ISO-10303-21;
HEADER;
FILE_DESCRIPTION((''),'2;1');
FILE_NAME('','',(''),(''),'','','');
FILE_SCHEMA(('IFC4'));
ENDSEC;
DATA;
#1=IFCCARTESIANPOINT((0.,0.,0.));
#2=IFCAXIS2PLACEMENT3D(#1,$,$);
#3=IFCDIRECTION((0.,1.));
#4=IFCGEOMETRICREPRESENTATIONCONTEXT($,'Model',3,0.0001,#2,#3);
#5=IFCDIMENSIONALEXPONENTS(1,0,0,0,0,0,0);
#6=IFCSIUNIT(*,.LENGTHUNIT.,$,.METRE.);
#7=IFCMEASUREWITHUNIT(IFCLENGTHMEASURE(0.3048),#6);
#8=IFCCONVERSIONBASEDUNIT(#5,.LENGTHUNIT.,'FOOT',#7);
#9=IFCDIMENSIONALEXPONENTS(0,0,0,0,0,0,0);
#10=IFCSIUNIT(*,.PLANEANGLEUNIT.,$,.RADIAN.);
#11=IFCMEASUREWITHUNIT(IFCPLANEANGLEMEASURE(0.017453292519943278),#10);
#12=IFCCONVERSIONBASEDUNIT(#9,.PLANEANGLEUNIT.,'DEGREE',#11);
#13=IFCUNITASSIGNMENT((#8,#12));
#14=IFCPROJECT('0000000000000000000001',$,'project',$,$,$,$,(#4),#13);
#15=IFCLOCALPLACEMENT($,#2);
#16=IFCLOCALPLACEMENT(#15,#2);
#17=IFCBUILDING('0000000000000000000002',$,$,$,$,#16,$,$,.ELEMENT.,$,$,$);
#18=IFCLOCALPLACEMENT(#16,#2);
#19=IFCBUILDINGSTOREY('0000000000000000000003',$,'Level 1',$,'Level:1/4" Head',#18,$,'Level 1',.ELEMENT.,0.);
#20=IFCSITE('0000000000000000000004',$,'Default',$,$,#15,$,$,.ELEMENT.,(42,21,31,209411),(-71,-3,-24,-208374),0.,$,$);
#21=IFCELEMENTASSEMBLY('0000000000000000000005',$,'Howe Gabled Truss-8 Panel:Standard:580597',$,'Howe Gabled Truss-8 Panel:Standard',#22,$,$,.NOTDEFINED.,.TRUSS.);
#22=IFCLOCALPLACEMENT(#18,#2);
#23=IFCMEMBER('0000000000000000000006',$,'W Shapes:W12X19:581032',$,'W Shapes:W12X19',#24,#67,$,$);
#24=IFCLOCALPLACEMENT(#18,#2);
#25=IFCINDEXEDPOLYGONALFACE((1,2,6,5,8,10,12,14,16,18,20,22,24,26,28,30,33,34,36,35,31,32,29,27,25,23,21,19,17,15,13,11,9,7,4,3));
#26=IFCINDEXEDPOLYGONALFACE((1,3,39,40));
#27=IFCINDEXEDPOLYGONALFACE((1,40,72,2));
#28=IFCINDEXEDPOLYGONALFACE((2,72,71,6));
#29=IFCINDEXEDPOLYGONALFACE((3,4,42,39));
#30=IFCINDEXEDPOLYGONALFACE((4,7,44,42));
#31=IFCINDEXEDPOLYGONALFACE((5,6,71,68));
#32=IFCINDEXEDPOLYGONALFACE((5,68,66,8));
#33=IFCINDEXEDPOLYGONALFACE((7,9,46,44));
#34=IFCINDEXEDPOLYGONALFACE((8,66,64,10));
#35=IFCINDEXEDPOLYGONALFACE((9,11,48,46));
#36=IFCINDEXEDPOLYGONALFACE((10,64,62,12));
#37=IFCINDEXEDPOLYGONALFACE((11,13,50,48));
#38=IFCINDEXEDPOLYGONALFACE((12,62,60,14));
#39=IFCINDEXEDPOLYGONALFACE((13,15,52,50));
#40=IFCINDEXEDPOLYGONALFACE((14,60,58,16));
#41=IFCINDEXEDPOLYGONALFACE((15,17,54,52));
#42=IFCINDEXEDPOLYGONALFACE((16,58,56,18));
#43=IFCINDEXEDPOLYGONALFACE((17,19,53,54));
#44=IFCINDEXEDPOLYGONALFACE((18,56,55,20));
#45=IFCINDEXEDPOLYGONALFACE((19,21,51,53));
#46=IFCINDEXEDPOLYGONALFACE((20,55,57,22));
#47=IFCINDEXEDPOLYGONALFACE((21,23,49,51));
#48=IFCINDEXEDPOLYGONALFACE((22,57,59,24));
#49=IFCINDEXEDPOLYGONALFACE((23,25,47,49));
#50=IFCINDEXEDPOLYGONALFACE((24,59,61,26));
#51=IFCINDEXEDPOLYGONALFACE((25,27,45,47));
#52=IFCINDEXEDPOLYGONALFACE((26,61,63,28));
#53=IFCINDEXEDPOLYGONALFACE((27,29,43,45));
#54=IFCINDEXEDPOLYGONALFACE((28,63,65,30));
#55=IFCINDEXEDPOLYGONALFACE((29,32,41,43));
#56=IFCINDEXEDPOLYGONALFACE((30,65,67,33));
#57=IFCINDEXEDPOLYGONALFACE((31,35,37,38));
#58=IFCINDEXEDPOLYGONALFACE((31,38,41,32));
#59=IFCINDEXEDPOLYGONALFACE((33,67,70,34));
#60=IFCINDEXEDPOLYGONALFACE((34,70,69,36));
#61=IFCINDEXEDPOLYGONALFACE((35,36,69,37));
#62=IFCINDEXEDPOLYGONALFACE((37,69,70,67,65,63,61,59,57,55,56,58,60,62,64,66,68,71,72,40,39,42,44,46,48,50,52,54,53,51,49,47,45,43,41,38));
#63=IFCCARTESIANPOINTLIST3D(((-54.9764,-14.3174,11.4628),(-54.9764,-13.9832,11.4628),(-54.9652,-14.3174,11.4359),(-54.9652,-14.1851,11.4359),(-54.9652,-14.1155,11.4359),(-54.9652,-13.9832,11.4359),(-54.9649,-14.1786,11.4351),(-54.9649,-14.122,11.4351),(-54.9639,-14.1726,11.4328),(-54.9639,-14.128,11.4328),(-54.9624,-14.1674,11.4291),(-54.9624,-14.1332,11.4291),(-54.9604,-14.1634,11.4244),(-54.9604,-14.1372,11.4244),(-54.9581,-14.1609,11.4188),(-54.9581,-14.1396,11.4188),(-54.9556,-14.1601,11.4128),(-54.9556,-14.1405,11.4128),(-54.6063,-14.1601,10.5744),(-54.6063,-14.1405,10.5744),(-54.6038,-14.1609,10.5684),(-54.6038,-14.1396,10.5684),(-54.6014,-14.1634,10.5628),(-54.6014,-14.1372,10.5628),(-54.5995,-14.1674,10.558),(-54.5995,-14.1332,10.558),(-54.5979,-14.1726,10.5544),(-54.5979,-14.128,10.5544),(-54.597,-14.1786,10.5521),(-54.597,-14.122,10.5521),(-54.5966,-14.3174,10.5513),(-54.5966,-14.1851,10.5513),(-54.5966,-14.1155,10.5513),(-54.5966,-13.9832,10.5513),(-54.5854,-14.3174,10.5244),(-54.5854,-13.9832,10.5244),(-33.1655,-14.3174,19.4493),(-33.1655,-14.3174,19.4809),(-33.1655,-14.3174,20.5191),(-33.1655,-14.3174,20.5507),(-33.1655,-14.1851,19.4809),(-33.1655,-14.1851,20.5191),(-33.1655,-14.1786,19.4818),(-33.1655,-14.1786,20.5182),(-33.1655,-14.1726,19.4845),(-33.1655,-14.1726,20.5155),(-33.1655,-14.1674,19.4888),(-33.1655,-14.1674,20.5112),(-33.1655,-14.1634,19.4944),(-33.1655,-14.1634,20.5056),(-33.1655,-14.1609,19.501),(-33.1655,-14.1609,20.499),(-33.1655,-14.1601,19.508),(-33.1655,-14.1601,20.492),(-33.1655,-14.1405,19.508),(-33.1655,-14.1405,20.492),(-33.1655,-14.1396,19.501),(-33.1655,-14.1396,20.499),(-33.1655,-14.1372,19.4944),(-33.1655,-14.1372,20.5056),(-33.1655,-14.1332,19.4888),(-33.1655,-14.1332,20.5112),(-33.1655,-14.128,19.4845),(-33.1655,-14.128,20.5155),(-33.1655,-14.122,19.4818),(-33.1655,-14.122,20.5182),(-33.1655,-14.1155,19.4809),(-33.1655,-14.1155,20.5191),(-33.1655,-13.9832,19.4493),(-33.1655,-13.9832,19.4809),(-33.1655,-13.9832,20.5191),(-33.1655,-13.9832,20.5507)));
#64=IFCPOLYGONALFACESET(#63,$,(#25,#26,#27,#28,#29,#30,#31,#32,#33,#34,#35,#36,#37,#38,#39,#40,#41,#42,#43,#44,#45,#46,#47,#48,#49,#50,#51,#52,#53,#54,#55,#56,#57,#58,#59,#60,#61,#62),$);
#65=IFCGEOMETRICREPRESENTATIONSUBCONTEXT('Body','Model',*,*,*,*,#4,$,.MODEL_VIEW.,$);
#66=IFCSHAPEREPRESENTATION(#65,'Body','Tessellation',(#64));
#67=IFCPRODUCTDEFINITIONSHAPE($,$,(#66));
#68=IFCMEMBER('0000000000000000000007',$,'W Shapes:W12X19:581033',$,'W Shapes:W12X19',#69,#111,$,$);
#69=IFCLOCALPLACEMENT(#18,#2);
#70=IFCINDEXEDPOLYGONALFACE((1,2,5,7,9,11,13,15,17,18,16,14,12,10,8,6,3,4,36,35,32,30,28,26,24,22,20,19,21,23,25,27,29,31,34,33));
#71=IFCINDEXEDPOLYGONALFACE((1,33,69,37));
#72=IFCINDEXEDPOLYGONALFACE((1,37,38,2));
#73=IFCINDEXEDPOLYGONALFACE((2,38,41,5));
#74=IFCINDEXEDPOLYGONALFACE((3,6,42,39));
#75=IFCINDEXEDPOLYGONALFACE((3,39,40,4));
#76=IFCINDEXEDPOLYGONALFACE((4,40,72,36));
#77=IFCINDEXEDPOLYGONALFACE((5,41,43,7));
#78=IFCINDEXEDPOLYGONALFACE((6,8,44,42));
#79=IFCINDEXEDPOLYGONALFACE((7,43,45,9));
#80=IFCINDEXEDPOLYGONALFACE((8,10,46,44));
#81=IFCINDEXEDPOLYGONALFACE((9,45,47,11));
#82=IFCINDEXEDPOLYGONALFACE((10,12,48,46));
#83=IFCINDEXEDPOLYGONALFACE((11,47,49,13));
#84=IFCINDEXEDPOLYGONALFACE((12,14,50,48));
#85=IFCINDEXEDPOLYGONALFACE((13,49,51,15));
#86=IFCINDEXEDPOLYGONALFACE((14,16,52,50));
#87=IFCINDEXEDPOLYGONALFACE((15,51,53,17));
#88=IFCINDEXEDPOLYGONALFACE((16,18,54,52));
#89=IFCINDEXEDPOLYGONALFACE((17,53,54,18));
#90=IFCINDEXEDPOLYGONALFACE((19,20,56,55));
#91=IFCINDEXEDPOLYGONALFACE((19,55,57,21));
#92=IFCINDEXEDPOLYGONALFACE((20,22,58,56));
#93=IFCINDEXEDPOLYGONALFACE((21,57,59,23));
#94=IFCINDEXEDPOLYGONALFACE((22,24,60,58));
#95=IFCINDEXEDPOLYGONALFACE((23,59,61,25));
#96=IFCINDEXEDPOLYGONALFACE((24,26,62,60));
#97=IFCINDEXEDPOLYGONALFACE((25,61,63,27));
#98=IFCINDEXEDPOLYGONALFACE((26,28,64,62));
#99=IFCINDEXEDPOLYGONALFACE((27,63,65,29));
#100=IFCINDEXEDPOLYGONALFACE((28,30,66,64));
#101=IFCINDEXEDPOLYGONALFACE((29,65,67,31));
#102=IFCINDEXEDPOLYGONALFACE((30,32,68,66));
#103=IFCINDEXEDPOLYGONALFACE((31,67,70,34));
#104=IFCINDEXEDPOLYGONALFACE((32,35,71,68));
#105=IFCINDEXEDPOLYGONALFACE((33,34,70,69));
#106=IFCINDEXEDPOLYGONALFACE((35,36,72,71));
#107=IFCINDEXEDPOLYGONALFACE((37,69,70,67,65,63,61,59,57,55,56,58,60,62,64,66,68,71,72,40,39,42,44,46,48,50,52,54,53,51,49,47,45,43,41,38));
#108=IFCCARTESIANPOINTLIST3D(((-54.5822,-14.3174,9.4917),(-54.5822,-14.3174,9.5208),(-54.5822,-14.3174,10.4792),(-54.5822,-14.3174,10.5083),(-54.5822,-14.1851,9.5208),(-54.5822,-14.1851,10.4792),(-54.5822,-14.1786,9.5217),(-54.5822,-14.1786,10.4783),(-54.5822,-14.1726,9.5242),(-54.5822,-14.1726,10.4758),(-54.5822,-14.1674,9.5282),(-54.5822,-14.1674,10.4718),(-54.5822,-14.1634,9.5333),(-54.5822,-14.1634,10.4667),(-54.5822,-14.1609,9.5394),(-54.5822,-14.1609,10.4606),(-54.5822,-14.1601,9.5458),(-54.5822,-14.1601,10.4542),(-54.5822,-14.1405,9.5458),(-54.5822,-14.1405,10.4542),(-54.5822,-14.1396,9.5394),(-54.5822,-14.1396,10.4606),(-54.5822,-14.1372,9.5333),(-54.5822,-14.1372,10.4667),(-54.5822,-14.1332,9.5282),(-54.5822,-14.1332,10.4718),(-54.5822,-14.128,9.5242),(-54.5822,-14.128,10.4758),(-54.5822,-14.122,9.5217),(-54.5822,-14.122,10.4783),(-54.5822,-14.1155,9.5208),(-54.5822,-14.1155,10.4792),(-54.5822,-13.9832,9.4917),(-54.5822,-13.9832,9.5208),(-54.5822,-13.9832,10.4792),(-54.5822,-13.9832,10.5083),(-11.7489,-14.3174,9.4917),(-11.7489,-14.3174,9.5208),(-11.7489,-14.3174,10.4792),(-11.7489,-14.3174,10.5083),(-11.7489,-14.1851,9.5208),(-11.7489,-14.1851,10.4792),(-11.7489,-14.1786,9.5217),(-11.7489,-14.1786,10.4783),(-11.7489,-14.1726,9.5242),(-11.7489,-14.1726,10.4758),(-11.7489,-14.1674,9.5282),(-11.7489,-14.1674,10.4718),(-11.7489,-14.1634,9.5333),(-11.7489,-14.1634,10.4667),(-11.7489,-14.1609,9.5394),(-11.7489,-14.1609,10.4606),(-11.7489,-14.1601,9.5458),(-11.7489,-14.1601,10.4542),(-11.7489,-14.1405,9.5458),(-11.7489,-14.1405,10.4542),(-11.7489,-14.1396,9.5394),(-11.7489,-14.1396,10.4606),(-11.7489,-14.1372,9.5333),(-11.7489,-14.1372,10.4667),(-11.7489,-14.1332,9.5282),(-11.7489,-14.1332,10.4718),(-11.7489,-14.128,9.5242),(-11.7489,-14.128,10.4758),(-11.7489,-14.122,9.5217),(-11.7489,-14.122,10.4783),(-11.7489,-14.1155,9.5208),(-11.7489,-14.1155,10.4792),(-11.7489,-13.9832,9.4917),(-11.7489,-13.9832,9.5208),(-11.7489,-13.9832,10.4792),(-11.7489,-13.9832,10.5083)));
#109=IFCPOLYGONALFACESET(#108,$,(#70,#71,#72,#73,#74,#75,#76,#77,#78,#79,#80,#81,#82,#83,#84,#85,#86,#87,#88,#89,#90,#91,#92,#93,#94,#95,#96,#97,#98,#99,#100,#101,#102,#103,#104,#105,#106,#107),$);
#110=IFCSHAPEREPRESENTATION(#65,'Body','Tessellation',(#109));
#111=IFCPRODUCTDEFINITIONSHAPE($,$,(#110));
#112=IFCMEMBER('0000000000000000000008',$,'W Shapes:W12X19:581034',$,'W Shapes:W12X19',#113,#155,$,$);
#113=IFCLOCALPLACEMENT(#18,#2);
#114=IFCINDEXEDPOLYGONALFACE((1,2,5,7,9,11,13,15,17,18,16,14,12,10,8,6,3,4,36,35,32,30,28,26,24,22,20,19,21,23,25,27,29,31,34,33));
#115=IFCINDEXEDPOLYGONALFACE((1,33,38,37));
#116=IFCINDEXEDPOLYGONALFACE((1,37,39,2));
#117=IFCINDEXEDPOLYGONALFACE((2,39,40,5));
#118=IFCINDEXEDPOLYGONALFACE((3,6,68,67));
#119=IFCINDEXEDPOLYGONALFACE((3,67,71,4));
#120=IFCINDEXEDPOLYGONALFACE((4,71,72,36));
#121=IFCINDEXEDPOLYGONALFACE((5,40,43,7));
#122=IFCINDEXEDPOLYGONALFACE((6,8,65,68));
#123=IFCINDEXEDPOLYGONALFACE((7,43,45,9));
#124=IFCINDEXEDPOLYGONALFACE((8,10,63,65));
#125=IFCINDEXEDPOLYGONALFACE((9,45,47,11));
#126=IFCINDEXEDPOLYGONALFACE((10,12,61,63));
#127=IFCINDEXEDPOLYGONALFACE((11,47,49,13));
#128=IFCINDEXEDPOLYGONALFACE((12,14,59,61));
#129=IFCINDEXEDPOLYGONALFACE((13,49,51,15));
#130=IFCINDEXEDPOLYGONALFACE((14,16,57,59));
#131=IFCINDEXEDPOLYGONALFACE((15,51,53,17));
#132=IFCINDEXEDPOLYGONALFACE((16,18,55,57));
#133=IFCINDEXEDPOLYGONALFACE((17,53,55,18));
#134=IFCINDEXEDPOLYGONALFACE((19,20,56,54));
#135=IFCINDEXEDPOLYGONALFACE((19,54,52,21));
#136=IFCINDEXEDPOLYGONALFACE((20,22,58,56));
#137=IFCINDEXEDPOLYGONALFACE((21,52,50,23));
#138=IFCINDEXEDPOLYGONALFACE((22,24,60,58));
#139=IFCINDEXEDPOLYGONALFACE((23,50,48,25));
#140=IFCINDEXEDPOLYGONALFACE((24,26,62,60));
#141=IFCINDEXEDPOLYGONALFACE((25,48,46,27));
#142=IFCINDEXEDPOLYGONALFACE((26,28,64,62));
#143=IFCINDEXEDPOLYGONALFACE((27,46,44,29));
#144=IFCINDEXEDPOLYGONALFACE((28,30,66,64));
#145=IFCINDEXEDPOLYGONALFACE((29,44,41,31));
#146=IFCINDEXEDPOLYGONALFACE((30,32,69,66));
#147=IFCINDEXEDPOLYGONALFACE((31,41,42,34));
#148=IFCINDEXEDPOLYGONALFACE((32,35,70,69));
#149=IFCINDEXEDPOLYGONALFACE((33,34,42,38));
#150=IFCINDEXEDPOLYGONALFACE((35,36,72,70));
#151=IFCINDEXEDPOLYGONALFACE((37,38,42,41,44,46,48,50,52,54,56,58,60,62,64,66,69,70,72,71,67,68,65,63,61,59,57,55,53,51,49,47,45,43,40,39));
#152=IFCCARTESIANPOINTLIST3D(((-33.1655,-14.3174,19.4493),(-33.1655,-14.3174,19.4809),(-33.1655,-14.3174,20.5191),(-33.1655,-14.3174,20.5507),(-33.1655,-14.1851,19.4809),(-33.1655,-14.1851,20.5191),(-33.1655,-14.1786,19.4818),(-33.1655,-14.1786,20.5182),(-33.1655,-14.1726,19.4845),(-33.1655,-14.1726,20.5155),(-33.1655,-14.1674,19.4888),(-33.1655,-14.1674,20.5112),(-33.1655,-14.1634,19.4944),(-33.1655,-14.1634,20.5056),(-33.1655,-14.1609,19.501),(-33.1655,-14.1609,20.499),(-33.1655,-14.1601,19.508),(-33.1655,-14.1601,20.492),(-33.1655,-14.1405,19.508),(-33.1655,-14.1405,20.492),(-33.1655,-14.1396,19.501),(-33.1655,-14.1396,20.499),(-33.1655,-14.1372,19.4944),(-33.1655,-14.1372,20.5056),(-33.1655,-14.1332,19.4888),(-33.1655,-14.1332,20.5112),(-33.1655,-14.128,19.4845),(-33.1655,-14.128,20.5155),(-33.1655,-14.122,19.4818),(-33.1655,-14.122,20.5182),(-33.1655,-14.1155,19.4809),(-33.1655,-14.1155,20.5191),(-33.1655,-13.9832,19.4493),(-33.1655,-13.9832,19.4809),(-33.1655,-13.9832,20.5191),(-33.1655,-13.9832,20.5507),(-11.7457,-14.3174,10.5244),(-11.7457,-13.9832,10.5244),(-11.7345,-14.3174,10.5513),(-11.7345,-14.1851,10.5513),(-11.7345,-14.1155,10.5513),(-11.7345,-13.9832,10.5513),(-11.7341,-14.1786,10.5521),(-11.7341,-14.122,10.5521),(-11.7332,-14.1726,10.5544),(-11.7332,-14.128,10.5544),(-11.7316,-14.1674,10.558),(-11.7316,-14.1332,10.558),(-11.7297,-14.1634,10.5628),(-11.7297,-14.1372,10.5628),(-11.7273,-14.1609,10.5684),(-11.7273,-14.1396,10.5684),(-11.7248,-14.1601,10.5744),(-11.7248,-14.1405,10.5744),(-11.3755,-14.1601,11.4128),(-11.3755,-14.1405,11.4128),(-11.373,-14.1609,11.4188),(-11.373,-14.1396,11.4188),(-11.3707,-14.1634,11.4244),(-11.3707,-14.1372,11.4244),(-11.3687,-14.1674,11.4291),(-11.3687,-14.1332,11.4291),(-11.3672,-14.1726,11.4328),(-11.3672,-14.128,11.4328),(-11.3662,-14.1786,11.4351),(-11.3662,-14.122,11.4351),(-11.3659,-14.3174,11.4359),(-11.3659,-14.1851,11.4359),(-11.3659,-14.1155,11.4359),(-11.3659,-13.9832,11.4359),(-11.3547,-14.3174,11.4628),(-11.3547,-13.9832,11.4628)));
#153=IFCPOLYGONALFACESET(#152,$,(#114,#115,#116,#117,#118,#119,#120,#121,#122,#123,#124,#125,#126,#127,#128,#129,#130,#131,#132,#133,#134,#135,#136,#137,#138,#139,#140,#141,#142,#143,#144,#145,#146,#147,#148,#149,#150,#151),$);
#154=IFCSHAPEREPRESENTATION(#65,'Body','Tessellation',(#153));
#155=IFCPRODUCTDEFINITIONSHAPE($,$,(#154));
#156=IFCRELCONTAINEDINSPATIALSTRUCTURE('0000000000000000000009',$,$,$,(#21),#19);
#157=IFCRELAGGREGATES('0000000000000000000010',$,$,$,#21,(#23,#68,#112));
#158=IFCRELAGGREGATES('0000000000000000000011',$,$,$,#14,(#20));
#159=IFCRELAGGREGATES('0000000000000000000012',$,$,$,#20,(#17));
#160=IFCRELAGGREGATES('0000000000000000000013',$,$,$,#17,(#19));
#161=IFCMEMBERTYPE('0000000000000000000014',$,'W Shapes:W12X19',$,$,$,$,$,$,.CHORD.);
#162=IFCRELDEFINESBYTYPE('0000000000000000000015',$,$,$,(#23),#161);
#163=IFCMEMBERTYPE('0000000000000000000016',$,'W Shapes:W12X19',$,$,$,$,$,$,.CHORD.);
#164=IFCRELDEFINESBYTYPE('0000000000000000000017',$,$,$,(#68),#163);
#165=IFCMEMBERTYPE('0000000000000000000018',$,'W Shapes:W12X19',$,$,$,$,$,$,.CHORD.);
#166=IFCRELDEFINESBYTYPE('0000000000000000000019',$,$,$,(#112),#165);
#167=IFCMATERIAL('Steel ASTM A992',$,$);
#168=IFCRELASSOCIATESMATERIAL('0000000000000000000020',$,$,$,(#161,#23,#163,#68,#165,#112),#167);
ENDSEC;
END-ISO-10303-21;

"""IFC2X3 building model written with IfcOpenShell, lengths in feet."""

from ifc_helpers import new_model, entity, si_unit, converted_unit, direction, frame, frame_2d, origin, place, context, subcontext, project, spatial, polyline, circle_curve, parameter, trimmed, segment, composite_curve, i_section, outline, extrude, clip, halfspace, source, transform, mapped, material, type_object, type_shapes, element, aggregate, save


model = new_model("IFC2X3")

# Units and contexts
model_context = context("Model", 3, precision=0.0001, world=origin(), true_north=direction((0.0, 1.0)))
body_context = subcontext(model_context, "Body", "Model", "MODEL_VIEW")
ifc_project = project(units=[converted_unit("LENGTHUNIT", "FOOT", entity("IfcLengthMeasure", 0.3048), si_unit("LENGTHUNIT", "METRE"), dimensions=[1, 0, 0, 0, 0, 0, 0]), converted_unit("PLANEANGLEUNIT", "DEGREE", entity("IfcPlaneAngleMeasure", 0.017453292519943278), si_unit("PLANEANGLEUNIT", "RADIAN"), dimensions=[0, 0, 0, 0, 0, 0, 0])], contexts=[model_context])

# Site, building, storey
site_placement = place(None, origin())
site = spatial("IfcSite", under=ifc_project, at=site_placement, Name="Default", CompositionType="ELEMENT", RefLatitude=(42, 21, 31, 209411), RefLongitude=(-71, -3, -24, -208374), RefElevation=0.0)
building_placement = place(site_placement, origin())
building = spatial("IfcBuilding", under=site, at=building_placement, CompositionType="ELEMENT")
storey_placement = place(building_placement, origin())
storey = spatial("IfcBuildingStorey", under=building, at=storey_placement, Name="Level 1", ObjectType="Level:1/4\" Head", LongName="Level 1", CompositionType="ELEMENT", Elevation=0.0)

# Element assembly, members
assembly_placement = place(storey_placement, origin())
assembly = element("IfcElementAssembly", 1, at=assembly_placement, inside=storey, Name="Howe Gabled Truss-8 Panel:Standard:580597", ObjectType="Howe Gabled Truss-8 Panel:Standard", AssemblyPlace="NOTDEFINED", PredefinedType="TRUSS")
ifc_material = material(Name="Steel ASTM A992")
member_type_1 = type_object("IfcMemberType", Name="W Shapes:W12X19", PredefinedType="CHORD", material=ifc_material)
shared_shape_1 = source(origin(), body_context, "Body", "Clipping", [
    clip(extrude(i_section(OverallWidth=0.3342, OverallDepth=1.0167, WebThickness=0.0196, FlangeThickness=0.0292, FilletRadius=0.025, at=frame_2d((0.0, 0.0), x_axis=(1.0, 0.0))), frame((-54.7809, -14.1503, 10.9936), z_axis=(0.923077, 0.0, 0.384615), x_axis=(0.0, -1.0, 0.0)), (0.0, 0.0, 1.0), 23.6285), halfspace(frame((-33.1655, -14.1503, 20.5507), z_axis=(1.0, 0.0, 0.0), x_axis=(0.0, -1.0, 0.0)), False)),
])
type_shapes(member_type_1, [shared_shape_1])
member_1_placement = place(assembly_placement, origin())
member_1 = element("IfcMember", 2, at=member_1_placement, type_object=member_type_1, material=ifc_material, Name="W Shapes:W12X19:581032", ObjectType="W Shapes:W12X19", context=body_context, shape_type="MappedRepresentation", body=[
    mapped(shared_shape_1, transform((0.0, 0.0, 0.0), scale=1.0)),
])
member_type_2 = type_object("IfcMemberType", Name="W Shapes:W12X19", PredefinedType="CHORD", material=ifc_material)
shared_shape_2 = source(origin(), body_context, "Body", "SweptSolid", [
    extrude(outline(composite_curve([segment(polyline([(-0.1671, -0.4792), (-0.1671, -0.5083)]), True, "CONTINUOUS"), segment(polyline([(-0.1671, -0.5083), (0.1671, -0.5083)]), True, "CONTINUOUS"), segment(polyline([(0.1671, -0.5083), (0.1671, -0.4792)]), True, "CONTINUOUS"), segment(polyline([(0.1671, -0.4792), (0.0348, -0.4792)]), True, "CONTINUOUS"), segment(trimmed(circle_curve(frame_2d((0.0348, -0.4542), x_axis=(1.0, 0.0)), 0.025), [parameter(180.0)], [parameter(270.0)], True, "PARAMETER"), False, "CONTINUOUS"), segment(polyline([(0.0098, -0.4542), (0.0098, 0.4542)]), True, "CONTINUOUS"), segment(trimmed(circle_curve(frame_2d((0.0348, 0.4542), x_axis=(1.0, 0.0)), 0.025), [parameter(90.0)], [parameter(180.0)], True, "PARAMETER"), False, "CONTINUOUS"), segment(polyline([(0.0348, 0.4792), (0.1671, 0.4792)]), True, "CONTINUOUS"), segment(polyline([(0.1671, 0.4792), (0.1671, 0.5083)]), True, "CONTINUOUS"), segment(polyline([(0.1671, 0.5083), (-0.1671, 0.5083)]), True, "CONTINUOUS"), segment(polyline([(-0.1671, 0.5083), (-0.1671, 0.4792)]), True, "CONTINUOUS"), segment(polyline([(-0.1671, 0.4792), (-0.0348, 0.4792)]), True, "CONTINUOUS"), segment(trimmed(circle_curve(frame_2d((-0.0348, 0.4542), x_axis=(1.0, 0.0)), 0.025), [parameter(360.0)], [parameter(90.0)], True, "PARAMETER"), False, "CONTINUOUS"), segment(polyline([(-0.0098, 0.4542), (-0.0098, -0.4542)]), True, "CONTINUOUS"), segment(trimmed(circle_curve(frame_2d((-0.0348, -0.4542), x_axis=(1.0, 0.0)), 0.025), [parameter(270.0)], [parameter(360.0)], True, "PARAMETER"), False, "CONTINUOUS"), segment(polyline([(-0.0348, -0.4792), (-0.1671, -0.4792)]), True, "CONTINUOUS")], self_intersect=False)), frame((-21.4167, 0.0, 0.0), z_axis=(-1.0, 0.0, 0.0), x_axis=(0.0, -1.0, 0.0)), (0.0, 0.0, -1.0), 42.8333),
])
type_shapes(member_type_2, [shared_shape_2])
member_2_placement = place(assembly_placement, frame((-33.1655, -14.1503, 10.0)))
member_2 = element("IfcMember", 3, at=member_2_placement, type_object=member_type_2, material=ifc_material, Name="W Shapes:W12X19:581033", ObjectType="W Shapes:W12X19", context=body_context, shape_type="MappedRepresentation", body=[
    mapped(shared_shape_2, transform((0.0, 0.0, 0.0), scale=1.0)),
])
member_type_3 = type_object("IfcMemberType", Name="W Shapes:W12X19", PredefinedType="CHORD", material=ifc_material)
shared_shape_3 = source(origin(), body_context, "Body", "Clipping", [
    clip(extrude(i_section(OverallWidth=0.3342, OverallDepth=1.0167, WebThickness=0.0196, FlangeThickness=0.0292, FilletRadius=0.025, at=frame_2d((0.0, 0.0), x_axis=(1.0, 0.0))), frame((-33.3611, -14.1503, 20.0815), z_axis=(0.923077, 0.0, -0.384615), x_axis=(0.0, 1.0, 0.0)), (0.0, 0.0, 1.0), 23.6285), halfspace(frame((-33.1655, -14.1503, 20.5507), z_axis=(-1.0, 0.0, 0.0), x_axis=(0.0, 1.0, 0.0)), False)),
])
type_shapes(member_type_3, [shared_shape_3])
member_3_placement = place(assembly_placement, origin())
member_3 = element("IfcMember", 4, at=member_3_placement, type_object=member_type_3, material=ifc_material, Name="W Shapes:W12X19:581034", ObjectType="W Shapes:W12X19", context=body_context, shape_type="MappedRepresentation", body=[
    mapped(shared_shape_3, transform((0.0, 0.0, 0.0), scale=1.0)),
])
aggregate(assembly, [member_1, member_2, member_3])

save(model, "model.ifc")
